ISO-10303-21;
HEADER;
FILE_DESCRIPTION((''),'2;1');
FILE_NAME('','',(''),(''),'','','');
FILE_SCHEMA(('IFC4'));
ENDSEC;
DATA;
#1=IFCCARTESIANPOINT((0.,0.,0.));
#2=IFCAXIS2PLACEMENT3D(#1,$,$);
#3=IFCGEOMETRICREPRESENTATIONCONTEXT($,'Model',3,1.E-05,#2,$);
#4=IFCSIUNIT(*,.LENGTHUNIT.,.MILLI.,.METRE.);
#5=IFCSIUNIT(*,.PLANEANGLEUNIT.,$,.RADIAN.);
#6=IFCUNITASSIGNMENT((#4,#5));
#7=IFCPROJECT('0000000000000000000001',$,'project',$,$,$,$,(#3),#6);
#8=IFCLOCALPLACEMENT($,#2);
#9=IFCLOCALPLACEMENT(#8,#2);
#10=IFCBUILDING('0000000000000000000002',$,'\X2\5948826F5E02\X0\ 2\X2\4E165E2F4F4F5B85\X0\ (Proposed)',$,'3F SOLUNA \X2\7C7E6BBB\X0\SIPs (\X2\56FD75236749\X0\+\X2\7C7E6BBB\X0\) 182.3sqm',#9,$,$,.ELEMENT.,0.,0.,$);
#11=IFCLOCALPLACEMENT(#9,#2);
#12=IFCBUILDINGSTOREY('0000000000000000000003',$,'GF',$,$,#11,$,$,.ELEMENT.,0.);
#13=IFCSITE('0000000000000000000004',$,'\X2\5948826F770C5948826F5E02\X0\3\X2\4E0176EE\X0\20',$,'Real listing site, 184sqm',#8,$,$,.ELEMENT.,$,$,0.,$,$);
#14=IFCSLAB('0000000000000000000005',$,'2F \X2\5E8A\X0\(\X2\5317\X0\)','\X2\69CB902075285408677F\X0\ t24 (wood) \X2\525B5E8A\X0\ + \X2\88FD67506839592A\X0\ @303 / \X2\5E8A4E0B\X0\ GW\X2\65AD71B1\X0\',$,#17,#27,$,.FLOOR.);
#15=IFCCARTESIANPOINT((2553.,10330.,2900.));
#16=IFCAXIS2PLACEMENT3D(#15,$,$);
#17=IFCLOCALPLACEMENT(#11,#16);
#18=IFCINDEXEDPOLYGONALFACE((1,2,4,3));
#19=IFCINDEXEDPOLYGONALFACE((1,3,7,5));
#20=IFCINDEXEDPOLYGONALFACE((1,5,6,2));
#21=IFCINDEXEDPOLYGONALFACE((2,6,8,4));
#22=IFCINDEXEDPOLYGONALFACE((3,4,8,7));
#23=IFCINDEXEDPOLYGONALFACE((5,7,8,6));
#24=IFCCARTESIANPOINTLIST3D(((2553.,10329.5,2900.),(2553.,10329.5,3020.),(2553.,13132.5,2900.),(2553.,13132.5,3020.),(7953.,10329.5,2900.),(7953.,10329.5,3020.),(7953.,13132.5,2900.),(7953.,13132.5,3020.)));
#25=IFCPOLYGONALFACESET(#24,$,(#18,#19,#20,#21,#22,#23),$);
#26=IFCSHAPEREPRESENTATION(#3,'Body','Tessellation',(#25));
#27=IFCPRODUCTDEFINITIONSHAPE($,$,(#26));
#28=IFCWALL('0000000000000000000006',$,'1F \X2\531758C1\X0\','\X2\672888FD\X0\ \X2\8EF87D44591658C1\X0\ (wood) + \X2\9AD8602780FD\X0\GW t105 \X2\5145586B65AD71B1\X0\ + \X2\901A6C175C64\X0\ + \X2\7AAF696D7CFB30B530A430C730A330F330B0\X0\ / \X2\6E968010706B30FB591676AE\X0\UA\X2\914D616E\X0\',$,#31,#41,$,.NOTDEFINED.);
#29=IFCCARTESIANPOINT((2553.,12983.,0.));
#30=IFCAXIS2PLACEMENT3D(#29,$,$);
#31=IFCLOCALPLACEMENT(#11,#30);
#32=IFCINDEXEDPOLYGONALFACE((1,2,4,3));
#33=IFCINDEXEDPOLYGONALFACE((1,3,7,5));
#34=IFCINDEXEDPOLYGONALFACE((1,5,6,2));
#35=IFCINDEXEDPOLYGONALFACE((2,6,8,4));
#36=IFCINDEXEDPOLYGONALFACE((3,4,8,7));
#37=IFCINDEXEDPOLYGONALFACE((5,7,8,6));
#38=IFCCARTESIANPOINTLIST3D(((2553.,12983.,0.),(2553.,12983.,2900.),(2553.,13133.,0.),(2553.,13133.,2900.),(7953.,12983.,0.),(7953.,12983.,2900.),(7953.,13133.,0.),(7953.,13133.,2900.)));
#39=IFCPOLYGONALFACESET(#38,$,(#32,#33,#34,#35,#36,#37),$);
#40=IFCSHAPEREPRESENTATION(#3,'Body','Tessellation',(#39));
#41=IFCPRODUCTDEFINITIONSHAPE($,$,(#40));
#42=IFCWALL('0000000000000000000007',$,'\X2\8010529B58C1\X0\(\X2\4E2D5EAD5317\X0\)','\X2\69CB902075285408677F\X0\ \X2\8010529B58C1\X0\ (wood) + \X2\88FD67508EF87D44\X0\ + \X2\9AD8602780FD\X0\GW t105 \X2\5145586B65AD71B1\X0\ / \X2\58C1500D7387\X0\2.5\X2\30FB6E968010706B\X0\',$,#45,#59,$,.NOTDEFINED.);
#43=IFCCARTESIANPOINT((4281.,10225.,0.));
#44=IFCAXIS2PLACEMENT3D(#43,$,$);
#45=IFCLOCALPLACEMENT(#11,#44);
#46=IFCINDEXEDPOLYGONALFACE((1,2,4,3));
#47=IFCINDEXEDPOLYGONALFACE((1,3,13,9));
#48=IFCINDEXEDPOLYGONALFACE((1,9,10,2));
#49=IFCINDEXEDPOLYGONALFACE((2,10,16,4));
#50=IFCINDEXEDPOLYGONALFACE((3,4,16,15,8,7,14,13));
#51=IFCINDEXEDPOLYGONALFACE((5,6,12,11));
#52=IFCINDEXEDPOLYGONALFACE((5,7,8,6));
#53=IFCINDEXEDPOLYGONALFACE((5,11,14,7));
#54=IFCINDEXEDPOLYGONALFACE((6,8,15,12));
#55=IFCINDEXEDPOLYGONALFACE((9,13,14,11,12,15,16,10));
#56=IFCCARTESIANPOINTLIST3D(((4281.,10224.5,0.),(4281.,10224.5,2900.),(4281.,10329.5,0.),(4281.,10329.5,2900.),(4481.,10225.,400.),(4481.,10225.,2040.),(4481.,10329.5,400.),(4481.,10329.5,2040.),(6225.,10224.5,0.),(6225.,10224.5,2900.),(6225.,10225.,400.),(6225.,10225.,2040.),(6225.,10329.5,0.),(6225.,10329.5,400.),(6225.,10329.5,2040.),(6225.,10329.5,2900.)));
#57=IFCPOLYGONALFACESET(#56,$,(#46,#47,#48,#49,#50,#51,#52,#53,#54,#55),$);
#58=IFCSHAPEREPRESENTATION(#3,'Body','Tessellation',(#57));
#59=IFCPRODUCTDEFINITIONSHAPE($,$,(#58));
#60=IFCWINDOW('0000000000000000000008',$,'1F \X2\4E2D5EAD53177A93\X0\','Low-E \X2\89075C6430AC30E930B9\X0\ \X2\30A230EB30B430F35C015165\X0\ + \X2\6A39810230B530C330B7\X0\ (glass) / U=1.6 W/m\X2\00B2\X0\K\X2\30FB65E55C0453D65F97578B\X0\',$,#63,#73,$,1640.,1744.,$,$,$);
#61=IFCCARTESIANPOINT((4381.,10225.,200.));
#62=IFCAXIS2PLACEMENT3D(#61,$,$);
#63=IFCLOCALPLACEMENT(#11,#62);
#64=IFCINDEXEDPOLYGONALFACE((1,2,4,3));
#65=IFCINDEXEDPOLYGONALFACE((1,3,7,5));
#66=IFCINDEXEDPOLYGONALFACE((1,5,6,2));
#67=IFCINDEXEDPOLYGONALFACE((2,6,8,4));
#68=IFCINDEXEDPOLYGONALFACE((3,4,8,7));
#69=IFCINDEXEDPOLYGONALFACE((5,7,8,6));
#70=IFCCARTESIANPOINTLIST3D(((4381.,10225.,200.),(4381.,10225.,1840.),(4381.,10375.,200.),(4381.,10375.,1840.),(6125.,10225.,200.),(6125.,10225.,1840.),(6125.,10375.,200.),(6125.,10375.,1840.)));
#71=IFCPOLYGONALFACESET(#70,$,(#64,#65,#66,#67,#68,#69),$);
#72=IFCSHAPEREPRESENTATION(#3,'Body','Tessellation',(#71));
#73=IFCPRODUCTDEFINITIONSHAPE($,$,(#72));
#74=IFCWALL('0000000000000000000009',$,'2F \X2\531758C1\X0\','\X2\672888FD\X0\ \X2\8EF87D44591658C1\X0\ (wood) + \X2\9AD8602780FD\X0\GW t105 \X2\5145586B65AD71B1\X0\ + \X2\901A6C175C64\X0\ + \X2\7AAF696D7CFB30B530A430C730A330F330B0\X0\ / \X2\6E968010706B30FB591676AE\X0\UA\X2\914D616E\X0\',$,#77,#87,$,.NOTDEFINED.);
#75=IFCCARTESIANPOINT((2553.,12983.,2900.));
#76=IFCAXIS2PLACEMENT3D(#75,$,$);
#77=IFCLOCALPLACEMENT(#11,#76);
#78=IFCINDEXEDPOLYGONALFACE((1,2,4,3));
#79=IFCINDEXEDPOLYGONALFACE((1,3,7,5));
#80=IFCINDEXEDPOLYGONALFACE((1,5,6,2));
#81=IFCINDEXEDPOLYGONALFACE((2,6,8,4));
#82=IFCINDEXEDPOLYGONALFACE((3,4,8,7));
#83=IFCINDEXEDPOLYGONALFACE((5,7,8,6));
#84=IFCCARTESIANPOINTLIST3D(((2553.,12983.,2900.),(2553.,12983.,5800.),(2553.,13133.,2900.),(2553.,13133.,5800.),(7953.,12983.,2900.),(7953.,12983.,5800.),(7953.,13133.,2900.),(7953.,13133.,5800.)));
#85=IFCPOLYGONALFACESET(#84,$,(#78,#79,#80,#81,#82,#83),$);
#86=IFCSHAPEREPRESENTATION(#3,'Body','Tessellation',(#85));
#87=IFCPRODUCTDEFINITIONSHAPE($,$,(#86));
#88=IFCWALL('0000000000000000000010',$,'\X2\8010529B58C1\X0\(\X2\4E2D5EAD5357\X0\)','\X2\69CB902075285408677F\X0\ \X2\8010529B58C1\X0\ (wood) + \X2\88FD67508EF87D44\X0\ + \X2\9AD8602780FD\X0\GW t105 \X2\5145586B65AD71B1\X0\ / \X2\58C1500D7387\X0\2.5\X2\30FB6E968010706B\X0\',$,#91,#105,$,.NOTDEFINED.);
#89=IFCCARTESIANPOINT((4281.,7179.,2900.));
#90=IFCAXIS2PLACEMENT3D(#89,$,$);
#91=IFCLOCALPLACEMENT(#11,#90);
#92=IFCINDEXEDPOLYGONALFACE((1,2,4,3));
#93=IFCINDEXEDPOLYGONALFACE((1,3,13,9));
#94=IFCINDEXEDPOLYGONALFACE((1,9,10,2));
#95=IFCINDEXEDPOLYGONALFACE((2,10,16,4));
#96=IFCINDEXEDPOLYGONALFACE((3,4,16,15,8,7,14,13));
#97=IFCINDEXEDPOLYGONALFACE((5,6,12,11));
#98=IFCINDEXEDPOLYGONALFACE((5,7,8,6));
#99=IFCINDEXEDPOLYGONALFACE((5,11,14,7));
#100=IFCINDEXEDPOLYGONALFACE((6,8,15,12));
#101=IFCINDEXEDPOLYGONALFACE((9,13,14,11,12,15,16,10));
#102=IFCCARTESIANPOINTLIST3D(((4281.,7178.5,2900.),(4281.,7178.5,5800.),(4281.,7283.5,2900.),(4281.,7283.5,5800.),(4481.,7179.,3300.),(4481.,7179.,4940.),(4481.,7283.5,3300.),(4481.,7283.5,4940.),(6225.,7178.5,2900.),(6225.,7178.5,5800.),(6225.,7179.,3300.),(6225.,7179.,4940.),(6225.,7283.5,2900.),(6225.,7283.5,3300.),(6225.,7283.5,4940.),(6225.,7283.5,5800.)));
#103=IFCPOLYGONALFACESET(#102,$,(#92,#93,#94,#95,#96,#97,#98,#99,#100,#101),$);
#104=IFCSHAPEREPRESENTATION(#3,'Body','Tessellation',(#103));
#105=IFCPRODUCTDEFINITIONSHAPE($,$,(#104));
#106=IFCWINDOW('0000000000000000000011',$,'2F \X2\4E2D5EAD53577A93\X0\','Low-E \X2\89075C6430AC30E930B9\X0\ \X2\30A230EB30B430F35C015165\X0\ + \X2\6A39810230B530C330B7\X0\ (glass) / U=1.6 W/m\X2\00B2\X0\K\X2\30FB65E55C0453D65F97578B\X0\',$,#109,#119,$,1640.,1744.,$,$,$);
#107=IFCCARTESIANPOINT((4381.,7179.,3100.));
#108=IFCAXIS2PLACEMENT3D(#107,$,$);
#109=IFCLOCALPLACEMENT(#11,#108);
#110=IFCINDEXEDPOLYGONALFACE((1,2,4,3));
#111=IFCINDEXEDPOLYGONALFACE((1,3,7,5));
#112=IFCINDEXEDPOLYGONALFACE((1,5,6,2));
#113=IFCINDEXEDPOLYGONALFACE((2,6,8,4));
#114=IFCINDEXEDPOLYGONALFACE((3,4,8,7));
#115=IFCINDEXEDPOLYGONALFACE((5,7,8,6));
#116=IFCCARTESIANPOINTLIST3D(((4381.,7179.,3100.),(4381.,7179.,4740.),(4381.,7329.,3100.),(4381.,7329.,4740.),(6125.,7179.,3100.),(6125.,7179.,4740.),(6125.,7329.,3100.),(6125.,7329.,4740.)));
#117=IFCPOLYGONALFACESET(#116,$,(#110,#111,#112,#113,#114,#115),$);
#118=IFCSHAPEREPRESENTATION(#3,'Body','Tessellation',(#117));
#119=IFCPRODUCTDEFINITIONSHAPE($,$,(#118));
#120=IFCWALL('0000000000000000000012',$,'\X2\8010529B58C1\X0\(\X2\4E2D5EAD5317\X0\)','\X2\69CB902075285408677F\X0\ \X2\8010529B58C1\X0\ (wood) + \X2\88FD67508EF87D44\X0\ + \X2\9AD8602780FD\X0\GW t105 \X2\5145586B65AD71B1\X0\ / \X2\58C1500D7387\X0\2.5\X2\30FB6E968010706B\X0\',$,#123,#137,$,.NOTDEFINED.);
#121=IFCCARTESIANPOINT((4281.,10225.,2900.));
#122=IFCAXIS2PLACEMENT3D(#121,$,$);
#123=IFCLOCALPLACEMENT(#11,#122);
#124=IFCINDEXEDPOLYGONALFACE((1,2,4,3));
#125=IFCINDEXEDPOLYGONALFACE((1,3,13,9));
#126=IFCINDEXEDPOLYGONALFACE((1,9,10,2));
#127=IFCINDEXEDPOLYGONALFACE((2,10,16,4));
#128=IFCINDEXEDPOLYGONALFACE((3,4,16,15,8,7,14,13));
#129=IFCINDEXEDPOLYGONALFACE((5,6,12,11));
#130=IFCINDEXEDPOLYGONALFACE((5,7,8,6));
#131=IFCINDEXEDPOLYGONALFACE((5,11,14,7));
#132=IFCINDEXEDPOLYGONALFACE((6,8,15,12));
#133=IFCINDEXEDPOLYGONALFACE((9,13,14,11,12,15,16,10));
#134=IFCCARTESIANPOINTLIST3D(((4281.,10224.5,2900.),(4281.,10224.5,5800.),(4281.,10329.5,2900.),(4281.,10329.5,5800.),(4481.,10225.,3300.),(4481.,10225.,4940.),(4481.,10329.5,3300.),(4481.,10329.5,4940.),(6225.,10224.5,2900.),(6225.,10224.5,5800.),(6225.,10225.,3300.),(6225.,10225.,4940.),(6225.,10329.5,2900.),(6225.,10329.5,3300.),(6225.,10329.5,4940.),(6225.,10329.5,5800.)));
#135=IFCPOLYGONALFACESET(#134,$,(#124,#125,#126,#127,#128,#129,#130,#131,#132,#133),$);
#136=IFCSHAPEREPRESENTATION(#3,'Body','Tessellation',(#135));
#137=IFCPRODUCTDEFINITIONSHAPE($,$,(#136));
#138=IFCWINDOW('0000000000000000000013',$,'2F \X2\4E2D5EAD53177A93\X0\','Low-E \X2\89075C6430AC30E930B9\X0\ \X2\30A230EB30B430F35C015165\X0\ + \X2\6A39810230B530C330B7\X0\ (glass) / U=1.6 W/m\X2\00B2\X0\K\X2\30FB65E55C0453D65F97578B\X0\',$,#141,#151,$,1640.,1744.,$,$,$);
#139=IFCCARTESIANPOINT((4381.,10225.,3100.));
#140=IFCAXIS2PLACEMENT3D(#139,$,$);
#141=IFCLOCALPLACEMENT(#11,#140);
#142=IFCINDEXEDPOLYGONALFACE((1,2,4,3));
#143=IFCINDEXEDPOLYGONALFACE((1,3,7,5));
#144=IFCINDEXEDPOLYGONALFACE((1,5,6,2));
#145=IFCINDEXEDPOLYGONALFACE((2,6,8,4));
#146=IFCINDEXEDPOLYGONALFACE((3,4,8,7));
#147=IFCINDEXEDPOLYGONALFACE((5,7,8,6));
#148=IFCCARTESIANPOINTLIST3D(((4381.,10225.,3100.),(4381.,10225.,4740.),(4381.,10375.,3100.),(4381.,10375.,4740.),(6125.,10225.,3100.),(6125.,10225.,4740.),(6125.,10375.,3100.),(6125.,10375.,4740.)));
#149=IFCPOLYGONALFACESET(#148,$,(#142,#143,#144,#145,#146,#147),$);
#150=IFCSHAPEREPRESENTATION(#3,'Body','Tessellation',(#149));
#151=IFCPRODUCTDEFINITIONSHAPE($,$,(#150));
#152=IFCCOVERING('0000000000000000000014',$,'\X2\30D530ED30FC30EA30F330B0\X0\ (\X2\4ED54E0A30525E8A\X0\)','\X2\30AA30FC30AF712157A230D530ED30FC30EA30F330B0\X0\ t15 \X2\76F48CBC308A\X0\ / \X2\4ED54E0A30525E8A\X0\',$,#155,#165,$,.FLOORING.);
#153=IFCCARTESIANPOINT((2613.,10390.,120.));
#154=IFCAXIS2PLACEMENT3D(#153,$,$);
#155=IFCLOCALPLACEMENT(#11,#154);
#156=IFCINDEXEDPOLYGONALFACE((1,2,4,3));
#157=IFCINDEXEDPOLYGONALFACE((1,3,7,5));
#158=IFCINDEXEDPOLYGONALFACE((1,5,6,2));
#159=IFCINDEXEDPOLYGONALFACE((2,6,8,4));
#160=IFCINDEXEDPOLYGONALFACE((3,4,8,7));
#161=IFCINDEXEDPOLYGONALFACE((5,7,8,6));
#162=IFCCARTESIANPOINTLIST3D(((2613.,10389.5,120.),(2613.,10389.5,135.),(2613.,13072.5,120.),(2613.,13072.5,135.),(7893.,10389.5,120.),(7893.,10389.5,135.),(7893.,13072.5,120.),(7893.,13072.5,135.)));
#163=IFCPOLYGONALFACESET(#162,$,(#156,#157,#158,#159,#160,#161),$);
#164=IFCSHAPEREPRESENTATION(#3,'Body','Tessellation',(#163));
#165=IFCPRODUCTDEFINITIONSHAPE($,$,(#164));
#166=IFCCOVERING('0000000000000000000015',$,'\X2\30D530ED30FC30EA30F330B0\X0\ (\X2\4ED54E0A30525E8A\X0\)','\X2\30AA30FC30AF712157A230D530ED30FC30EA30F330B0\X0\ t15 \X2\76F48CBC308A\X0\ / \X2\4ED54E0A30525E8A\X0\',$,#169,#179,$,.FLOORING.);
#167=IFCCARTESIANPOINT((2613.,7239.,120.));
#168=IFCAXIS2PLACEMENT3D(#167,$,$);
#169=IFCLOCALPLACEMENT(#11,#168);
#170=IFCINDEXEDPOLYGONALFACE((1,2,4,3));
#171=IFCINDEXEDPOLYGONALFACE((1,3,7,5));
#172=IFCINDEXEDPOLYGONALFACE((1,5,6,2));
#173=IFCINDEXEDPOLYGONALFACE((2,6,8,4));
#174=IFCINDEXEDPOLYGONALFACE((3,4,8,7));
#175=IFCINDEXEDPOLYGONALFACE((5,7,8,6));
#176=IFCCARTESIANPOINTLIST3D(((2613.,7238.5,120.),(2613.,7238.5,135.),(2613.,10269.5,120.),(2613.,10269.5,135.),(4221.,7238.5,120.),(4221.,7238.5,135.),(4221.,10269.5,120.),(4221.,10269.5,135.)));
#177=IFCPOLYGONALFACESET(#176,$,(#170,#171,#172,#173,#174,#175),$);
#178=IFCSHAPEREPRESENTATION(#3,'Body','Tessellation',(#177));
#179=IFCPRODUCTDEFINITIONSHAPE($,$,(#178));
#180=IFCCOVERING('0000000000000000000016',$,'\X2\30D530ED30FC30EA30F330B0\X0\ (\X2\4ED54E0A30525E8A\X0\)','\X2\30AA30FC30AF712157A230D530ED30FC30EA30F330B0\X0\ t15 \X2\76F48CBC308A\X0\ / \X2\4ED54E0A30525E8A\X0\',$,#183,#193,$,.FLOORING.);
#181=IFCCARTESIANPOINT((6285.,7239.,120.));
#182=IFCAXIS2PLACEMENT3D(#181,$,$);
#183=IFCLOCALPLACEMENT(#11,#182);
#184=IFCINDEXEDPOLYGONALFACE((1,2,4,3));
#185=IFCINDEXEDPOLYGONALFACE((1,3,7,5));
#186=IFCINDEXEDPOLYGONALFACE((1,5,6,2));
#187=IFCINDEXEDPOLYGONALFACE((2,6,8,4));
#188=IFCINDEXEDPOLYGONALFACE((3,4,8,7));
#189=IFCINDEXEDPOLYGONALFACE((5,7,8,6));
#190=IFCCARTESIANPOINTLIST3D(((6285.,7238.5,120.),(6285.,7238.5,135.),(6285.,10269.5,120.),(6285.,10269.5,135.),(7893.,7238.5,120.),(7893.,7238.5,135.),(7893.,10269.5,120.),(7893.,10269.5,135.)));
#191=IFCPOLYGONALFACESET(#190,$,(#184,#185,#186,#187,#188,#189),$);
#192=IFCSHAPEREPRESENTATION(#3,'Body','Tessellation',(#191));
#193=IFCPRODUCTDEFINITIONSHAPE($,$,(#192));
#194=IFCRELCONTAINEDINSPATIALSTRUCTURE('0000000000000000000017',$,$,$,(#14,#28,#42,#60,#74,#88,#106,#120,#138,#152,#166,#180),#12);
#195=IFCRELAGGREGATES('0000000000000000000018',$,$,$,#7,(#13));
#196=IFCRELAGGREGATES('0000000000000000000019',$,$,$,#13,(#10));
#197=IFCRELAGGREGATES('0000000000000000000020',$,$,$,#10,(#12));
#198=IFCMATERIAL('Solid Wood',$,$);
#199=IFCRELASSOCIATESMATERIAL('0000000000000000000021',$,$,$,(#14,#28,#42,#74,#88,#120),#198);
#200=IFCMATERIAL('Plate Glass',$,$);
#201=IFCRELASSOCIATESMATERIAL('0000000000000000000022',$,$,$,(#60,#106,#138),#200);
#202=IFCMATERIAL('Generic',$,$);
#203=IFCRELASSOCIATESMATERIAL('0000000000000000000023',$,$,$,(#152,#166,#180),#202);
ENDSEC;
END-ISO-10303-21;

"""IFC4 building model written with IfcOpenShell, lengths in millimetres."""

from ifc_helpers import new_model, si_unit, frame, frame_2d, origin, place, context, project, spatial, rectangle, extrude, material, element, fill, save


model = new_model("IFC4")

# Units and contexts
model_context = context("Model", 3, precision=1e-05, world=origin())
ifc_project = project(units=[si_unit("LENGTHUNIT", "METRE", prefix="MILLI"), si_unit("PLANEANGLEUNIT", "RADIAN")], contexts=[model_context])

# Site, building, storey
site_placement = place(None, origin())
site = spatial("IfcSite", under=ifc_project, at=site_placement, Name="奈良県奈良市3丁目20", ObjectType="Real listing site, 184sqm", CompositionType="ELEMENT", RefElevation=0.0)
building_placement = place(site_placement, origin())
building = spatial("IfcBuilding", under=site, at=building_placement, Name="奈良市 2世帯住宅 (Proposed)", ObjectType="3F SOLUNA 籾殻SIPs (国産杉+籾殻) 182.3sqm", CompositionType="ELEMENT", ElevationOfRefHeight=0.0, ElevationOfTerrain=0.0)
storey_placement = place(building_placement, origin())
storey = spatial("IfcBuildingStorey", under=building, at=storey_placement, Name="GF", CompositionType="ELEMENT", Elevation=0.0)

# Slab
ifc_material_1 = material(Name="Solid Wood")
slab_1_placement = place(storey_placement, frame((2553.0, 10330.0, 2900.0)))
element("IfcSlab", 1, at=slab_1_placement, inside=storey, material=ifc_material_1, Name="2F 床(北)", Description="構造用合板 t24 (wood) 剛床 + 製材根太 @303 / 床下 GW断熱", PredefinedType="FLOOR", context=model_context, shape_type="SweptSolid", body=[
    extrude(rectangle(XDim=5400.0, YDim=2803.0, at=frame_2d((2700.0, 1401.0))), frame((2553.0, 10330.0, 2900.0)), (0.0, 0.0, 1.0), 120.0),
])

# Wall
wall_1_placement = place(storey_placement, frame((2553.0, 12983.0, 0.0)))
element("IfcWall", 2, at=wall_1_placement, inside=storey, material=ifc_material_1, Name="1F 北壁", Description="木製 軸組外壁 (wood) + 高性能GW t105 充填断熱 + 通気層 + 窯業系サイディング / 準耐火・外皮UA配慮", PredefinedType="NOTDEFINED", context=model_context, shape_type="SweptSolid", body=[
    extrude(rectangle(XDim=5400.0, YDim=150.0, at=frame_2d((2700.0, 75.0))), frame((2553.0, 12983.0, 0.0)), (0.0, 0.0, 1.0), 2900.0),
])

# Wall, opening, window
wall_2_placement = place(storey_placement, frame((4281.0, 10225.0, 0.0)))
wall_2 = element("IfcWall", 3, at=wall_2_placement, inside=storey, material=ifc_material_1, Name="耐力壁(中庭北)", Description="構造用合板 耐力壁 (wood) + 製材軸組 + 高性能GW t105 充填断熱 / 壁倍率2.5・準耐火", PredefinedType="NOTDEFINED", context=model_context, shape_type="SweptSolid", body=[
    extrude(rectangle(XDim=1944.0, YDim=105.0, at=frame_2d((972.0, 52.0))), frame((4281.0, 10225.0, 0.0)), (0.0, 0.0, 1.0), 2900.0),
])
opening_1_placement = place(storey_placement, frame((4381.0, 10225.0, 200.0)))
opening_1 = element("IfcOpeningElement", 4, at=opening_1_placement, cuts=wall_2, PredefinedType="NOTDEFINED", context=model_context, shape_type="SweptSolid", body=[
    extrude(rectangle(XDim=1744.0, YDim=150.0, at=frame_2d((872.0, 75.0))), frame((4381.0, 10225.0, 200.0)), (0.0, 0.0, 1.0), 1640.0),
])
ifc_material_2 = material(Name="Plate Glass")
window_1_placement = place(storey_placement, frame((4381.0, 10225.0, 200.0)))
window_1 = element("IfcWindow", 5, at=window_1_placement, inside=storey, material=ifc_material_2, Name="1F 中庭北窓", Description="Low-E 複層ガラス アルゴン封入 + 樹脂サッシ (glass) / U=1.6 W/m²K・日射取得型", OverallHeight=1640.0, OverallWidth=1744.0, context=model_context, shape_type="SweptSolid", body=[
    extrude(rectangle(XDim=1744.0, YDim=150.0, at=frame_2d((872.0, 75.0))), frame((4381.0, 10225.0, 200.0)), (0.0, 0.0, 1.0), 1640.0),
])
fill(opening_1, window_1)

# Wall
wall_3_placement = place(storey_placement, frame((2553.0, 12983.0, 2900.0)))
element("IfcWall", 6, at=wall_3_placement, inside=storey, material=ifc_material_1, Name="2F 北壁", Description="木製 軸組外壁 (wood) + 高性能GW t105 充填断熱 + 通気層 + 窯業系サイディング / 準耐火・外皮UA配慮", PredefinedType="NOTDEFINED", context=model_context, shape_type="SweptSolid", body=[
    extrude(rectangle(XDim=5400.0, YDim=150.0, at=frame_2d((2700.0, 75.0))), frame((2553.0, 12983.0, 2900.0)), (0.0, 0.0, 1.0), 2900.0),
])

# Walls, openings, windows
wall_4_placement = place(storey_placement, frame((4281.0, 7179.0, 2900.0)))
wall_4 = element("IfcWall", 7, at=wall_4_placement, inside=storey, material=ifc_material_1, Name="耐力壁(中庭南)", Description="構造用合板 耐力壁 (wood) + 製材軸組 + 高性能GW t105 充填断熱 / 壁倍率2.5・準耐火", PredefinedType="NOTDEFINED", context=model_context, shape_type="SweptSolid", body=[
    extrude(rectangle(XDim=1944.0, YDim=105.0, at=frame_2d((972.0, 52.0))), frame((4281.0, 7179.0, 2900.0)), (0.0, 0.0, 1.0), 2900.0),
])
opening_2_placement = place(storey_placement, frame((4381.0, 7179.0, 3100.0)))
opening_2 = element("IfcOpeningElement", 8, at=opening_2_placement, cuts=wall_4, PredefinedType="NOTDEFINED", context=model_context, shape_type="SweptSolid", body=[
    extrude(rectangle(XDim=1744.0, YDim=150.0, at=frame_2d((872.0, 75.0))), frame((4381.0, 7179.0, 3100.0)), (0.0, 0.0, 1.0), 1640.0),
])
window_2_placement = place(storey_placement, frame((4381.0, 7179.0, 3100.0)))
window_2 = element("IfcWindow", 9, at=window_2_placement, inside=storey, material=ifc_material_2, Name="2F 中庭南窓", Description="Low-E 複層ガラス アルゴン封入 + 樹脂サッシ (glass) / U=1.6 W/m²K・日射取得型", OverallHeight=1640.0, OverallWidth=1744.0, context=model_context, shape_type="SweptSolid", body=[
    extrude(rectangle(XDim=1744.0, YDim=150.0, at=frame_2d((872.0, 75.0))), frame((4381.0, 7179.0, 3100.0)), (0.0, 0.0, 1.0), 1640.0),
])
fill(opening_2, window_2)
wall_5_placement = place(storey_placement, frame((4281.0, 10225.0, 2900.0)))
wall_5 = element("IfcWall", 10, at=wall_5_placement, inside=storey, material=ifc_material_1, Name="耐力壁(中庭北)", Description="構造用合板 耐力壁 (wood) + 製材軸組 + 高性能GW t105 充填断熱 / 壁倍率2.5・準耐火", PredefinedType="NOTDEFINED", context=model_context, shape_type="SweptSolid", body=[
    extrude(rectangle(XDim=1944.0, YDim=105.0, at=frame_2d((972.0, 52.0))), frame((4281.0, 10225.0, 2900.0)), (0.0, 0.0, 1.0), 2900.0),
])
opening_3_placement = place(storey_placement, frame((4381.0, 10225.0, 3100.0)))
opening_3 = element("IfcOpeningElement", 11, at=opening_3_placement, cuts=wall_5, PredefinedType="NOTDEFINED", context=model_context, shape_type="SweptSolid", body=[
    extrude(rectangle(XDim=1744.0, YDim=150.0, at=frame_2d((872.0, 75.0))), frame((4381.0, 10225.0, 3100.0)), (0.0, 0.0, 1.0), 1640.0),
])
window_3_placement = place(storey_placement, frame((4381.0, 10225.0, 3100.0)))
window_3 = element("IfcWindow", 12, at=window_3_placement, inside=storey, material=ifc_material_2, Name="2F 中庭北窓", Description="Low-E 複層ガラス アルゴン封入 + 樹脂サッシ (glass) / U=1.6 W/m²K・日射取得型", OverallHeight=1640.0, OverallWidth=1744.0, context=model_context, shape_type="SweptSolid", body=[
    extrude(rectangle(XDim=1744.0, YDim=150.0, at=frame_2d((872.0, 75.0))), frame((4381.0, 10225.0, 3100.0)), (0.0, 0.0, 1.0), 1640.0),
])
fill(opening_3, window_3)

# Coverings
ifc_material_3 = material(Name="Generic")
covering_1_placement = place(storey_placement, frame((2613.0, 10390.0, 120.0)))
element("IfcCovering", 13, at=covering_1_placement, inside=storey, material=ifc_material_3, Name="フローリング (仕上げ床)", Description="オーク無垢フローリング t15 直貼り / 仕上げ床", PredefinedType="FLOORING", context=model_context, shape_type="SweptSolid", body=[
    extrude(rectangle(XDim=5280.0, YDim=2683.0, at=frame_2d((2640.0, 1341.0))), frame((2613.0, 10390.0, 120.0)), (0.0, 0.0, 1.0), 15.0),
])
covering_2_placement = place(storey_placement, frame((2613.0, 7239.0, 120.0)))
element("IfcCovering", 14, at=covering_2_placement, inside=storey, material=ifc_material_3, Name="フローリング (仕上げ床)", Description="オーク無垢フローリング t15 直貼り / 仕上げ床", PredefinedType="FLOORING", context=model_context, shape_type="SweptSolid", body=[
    extrude(rectangle(XDim=1608.0, YDim=3031.0, at=frame_2d((804.0, 1515.0))), frame((2613.0, 7239.0, 120.0)), (0.0, 0.0, 1.0), 15.0),
])
covering_3_placement = place(storey_placement, frame((6285.0, 7239.0, 120.0)))
element("IfcCovering", 15, at=covering_3_placement, inside=storey, material=ifc_material_3, Name="フローリング (仕上げ床)", Description="オーク無垢フローリング t15 直貼り / 仕上げ床", PredefinedType="FLOORING", context=model_context, shape_type="SweptSolid", body=[
    extrude(rectangle(XDim=1608.0, YDim=3031.0, at=frame_2d((804.0, 1515.0))), frame((6285.0, 7239.0, 120.0)), (0.0, 0.0, 1.0), 15.0),
])

save(model, "model.ifc")
